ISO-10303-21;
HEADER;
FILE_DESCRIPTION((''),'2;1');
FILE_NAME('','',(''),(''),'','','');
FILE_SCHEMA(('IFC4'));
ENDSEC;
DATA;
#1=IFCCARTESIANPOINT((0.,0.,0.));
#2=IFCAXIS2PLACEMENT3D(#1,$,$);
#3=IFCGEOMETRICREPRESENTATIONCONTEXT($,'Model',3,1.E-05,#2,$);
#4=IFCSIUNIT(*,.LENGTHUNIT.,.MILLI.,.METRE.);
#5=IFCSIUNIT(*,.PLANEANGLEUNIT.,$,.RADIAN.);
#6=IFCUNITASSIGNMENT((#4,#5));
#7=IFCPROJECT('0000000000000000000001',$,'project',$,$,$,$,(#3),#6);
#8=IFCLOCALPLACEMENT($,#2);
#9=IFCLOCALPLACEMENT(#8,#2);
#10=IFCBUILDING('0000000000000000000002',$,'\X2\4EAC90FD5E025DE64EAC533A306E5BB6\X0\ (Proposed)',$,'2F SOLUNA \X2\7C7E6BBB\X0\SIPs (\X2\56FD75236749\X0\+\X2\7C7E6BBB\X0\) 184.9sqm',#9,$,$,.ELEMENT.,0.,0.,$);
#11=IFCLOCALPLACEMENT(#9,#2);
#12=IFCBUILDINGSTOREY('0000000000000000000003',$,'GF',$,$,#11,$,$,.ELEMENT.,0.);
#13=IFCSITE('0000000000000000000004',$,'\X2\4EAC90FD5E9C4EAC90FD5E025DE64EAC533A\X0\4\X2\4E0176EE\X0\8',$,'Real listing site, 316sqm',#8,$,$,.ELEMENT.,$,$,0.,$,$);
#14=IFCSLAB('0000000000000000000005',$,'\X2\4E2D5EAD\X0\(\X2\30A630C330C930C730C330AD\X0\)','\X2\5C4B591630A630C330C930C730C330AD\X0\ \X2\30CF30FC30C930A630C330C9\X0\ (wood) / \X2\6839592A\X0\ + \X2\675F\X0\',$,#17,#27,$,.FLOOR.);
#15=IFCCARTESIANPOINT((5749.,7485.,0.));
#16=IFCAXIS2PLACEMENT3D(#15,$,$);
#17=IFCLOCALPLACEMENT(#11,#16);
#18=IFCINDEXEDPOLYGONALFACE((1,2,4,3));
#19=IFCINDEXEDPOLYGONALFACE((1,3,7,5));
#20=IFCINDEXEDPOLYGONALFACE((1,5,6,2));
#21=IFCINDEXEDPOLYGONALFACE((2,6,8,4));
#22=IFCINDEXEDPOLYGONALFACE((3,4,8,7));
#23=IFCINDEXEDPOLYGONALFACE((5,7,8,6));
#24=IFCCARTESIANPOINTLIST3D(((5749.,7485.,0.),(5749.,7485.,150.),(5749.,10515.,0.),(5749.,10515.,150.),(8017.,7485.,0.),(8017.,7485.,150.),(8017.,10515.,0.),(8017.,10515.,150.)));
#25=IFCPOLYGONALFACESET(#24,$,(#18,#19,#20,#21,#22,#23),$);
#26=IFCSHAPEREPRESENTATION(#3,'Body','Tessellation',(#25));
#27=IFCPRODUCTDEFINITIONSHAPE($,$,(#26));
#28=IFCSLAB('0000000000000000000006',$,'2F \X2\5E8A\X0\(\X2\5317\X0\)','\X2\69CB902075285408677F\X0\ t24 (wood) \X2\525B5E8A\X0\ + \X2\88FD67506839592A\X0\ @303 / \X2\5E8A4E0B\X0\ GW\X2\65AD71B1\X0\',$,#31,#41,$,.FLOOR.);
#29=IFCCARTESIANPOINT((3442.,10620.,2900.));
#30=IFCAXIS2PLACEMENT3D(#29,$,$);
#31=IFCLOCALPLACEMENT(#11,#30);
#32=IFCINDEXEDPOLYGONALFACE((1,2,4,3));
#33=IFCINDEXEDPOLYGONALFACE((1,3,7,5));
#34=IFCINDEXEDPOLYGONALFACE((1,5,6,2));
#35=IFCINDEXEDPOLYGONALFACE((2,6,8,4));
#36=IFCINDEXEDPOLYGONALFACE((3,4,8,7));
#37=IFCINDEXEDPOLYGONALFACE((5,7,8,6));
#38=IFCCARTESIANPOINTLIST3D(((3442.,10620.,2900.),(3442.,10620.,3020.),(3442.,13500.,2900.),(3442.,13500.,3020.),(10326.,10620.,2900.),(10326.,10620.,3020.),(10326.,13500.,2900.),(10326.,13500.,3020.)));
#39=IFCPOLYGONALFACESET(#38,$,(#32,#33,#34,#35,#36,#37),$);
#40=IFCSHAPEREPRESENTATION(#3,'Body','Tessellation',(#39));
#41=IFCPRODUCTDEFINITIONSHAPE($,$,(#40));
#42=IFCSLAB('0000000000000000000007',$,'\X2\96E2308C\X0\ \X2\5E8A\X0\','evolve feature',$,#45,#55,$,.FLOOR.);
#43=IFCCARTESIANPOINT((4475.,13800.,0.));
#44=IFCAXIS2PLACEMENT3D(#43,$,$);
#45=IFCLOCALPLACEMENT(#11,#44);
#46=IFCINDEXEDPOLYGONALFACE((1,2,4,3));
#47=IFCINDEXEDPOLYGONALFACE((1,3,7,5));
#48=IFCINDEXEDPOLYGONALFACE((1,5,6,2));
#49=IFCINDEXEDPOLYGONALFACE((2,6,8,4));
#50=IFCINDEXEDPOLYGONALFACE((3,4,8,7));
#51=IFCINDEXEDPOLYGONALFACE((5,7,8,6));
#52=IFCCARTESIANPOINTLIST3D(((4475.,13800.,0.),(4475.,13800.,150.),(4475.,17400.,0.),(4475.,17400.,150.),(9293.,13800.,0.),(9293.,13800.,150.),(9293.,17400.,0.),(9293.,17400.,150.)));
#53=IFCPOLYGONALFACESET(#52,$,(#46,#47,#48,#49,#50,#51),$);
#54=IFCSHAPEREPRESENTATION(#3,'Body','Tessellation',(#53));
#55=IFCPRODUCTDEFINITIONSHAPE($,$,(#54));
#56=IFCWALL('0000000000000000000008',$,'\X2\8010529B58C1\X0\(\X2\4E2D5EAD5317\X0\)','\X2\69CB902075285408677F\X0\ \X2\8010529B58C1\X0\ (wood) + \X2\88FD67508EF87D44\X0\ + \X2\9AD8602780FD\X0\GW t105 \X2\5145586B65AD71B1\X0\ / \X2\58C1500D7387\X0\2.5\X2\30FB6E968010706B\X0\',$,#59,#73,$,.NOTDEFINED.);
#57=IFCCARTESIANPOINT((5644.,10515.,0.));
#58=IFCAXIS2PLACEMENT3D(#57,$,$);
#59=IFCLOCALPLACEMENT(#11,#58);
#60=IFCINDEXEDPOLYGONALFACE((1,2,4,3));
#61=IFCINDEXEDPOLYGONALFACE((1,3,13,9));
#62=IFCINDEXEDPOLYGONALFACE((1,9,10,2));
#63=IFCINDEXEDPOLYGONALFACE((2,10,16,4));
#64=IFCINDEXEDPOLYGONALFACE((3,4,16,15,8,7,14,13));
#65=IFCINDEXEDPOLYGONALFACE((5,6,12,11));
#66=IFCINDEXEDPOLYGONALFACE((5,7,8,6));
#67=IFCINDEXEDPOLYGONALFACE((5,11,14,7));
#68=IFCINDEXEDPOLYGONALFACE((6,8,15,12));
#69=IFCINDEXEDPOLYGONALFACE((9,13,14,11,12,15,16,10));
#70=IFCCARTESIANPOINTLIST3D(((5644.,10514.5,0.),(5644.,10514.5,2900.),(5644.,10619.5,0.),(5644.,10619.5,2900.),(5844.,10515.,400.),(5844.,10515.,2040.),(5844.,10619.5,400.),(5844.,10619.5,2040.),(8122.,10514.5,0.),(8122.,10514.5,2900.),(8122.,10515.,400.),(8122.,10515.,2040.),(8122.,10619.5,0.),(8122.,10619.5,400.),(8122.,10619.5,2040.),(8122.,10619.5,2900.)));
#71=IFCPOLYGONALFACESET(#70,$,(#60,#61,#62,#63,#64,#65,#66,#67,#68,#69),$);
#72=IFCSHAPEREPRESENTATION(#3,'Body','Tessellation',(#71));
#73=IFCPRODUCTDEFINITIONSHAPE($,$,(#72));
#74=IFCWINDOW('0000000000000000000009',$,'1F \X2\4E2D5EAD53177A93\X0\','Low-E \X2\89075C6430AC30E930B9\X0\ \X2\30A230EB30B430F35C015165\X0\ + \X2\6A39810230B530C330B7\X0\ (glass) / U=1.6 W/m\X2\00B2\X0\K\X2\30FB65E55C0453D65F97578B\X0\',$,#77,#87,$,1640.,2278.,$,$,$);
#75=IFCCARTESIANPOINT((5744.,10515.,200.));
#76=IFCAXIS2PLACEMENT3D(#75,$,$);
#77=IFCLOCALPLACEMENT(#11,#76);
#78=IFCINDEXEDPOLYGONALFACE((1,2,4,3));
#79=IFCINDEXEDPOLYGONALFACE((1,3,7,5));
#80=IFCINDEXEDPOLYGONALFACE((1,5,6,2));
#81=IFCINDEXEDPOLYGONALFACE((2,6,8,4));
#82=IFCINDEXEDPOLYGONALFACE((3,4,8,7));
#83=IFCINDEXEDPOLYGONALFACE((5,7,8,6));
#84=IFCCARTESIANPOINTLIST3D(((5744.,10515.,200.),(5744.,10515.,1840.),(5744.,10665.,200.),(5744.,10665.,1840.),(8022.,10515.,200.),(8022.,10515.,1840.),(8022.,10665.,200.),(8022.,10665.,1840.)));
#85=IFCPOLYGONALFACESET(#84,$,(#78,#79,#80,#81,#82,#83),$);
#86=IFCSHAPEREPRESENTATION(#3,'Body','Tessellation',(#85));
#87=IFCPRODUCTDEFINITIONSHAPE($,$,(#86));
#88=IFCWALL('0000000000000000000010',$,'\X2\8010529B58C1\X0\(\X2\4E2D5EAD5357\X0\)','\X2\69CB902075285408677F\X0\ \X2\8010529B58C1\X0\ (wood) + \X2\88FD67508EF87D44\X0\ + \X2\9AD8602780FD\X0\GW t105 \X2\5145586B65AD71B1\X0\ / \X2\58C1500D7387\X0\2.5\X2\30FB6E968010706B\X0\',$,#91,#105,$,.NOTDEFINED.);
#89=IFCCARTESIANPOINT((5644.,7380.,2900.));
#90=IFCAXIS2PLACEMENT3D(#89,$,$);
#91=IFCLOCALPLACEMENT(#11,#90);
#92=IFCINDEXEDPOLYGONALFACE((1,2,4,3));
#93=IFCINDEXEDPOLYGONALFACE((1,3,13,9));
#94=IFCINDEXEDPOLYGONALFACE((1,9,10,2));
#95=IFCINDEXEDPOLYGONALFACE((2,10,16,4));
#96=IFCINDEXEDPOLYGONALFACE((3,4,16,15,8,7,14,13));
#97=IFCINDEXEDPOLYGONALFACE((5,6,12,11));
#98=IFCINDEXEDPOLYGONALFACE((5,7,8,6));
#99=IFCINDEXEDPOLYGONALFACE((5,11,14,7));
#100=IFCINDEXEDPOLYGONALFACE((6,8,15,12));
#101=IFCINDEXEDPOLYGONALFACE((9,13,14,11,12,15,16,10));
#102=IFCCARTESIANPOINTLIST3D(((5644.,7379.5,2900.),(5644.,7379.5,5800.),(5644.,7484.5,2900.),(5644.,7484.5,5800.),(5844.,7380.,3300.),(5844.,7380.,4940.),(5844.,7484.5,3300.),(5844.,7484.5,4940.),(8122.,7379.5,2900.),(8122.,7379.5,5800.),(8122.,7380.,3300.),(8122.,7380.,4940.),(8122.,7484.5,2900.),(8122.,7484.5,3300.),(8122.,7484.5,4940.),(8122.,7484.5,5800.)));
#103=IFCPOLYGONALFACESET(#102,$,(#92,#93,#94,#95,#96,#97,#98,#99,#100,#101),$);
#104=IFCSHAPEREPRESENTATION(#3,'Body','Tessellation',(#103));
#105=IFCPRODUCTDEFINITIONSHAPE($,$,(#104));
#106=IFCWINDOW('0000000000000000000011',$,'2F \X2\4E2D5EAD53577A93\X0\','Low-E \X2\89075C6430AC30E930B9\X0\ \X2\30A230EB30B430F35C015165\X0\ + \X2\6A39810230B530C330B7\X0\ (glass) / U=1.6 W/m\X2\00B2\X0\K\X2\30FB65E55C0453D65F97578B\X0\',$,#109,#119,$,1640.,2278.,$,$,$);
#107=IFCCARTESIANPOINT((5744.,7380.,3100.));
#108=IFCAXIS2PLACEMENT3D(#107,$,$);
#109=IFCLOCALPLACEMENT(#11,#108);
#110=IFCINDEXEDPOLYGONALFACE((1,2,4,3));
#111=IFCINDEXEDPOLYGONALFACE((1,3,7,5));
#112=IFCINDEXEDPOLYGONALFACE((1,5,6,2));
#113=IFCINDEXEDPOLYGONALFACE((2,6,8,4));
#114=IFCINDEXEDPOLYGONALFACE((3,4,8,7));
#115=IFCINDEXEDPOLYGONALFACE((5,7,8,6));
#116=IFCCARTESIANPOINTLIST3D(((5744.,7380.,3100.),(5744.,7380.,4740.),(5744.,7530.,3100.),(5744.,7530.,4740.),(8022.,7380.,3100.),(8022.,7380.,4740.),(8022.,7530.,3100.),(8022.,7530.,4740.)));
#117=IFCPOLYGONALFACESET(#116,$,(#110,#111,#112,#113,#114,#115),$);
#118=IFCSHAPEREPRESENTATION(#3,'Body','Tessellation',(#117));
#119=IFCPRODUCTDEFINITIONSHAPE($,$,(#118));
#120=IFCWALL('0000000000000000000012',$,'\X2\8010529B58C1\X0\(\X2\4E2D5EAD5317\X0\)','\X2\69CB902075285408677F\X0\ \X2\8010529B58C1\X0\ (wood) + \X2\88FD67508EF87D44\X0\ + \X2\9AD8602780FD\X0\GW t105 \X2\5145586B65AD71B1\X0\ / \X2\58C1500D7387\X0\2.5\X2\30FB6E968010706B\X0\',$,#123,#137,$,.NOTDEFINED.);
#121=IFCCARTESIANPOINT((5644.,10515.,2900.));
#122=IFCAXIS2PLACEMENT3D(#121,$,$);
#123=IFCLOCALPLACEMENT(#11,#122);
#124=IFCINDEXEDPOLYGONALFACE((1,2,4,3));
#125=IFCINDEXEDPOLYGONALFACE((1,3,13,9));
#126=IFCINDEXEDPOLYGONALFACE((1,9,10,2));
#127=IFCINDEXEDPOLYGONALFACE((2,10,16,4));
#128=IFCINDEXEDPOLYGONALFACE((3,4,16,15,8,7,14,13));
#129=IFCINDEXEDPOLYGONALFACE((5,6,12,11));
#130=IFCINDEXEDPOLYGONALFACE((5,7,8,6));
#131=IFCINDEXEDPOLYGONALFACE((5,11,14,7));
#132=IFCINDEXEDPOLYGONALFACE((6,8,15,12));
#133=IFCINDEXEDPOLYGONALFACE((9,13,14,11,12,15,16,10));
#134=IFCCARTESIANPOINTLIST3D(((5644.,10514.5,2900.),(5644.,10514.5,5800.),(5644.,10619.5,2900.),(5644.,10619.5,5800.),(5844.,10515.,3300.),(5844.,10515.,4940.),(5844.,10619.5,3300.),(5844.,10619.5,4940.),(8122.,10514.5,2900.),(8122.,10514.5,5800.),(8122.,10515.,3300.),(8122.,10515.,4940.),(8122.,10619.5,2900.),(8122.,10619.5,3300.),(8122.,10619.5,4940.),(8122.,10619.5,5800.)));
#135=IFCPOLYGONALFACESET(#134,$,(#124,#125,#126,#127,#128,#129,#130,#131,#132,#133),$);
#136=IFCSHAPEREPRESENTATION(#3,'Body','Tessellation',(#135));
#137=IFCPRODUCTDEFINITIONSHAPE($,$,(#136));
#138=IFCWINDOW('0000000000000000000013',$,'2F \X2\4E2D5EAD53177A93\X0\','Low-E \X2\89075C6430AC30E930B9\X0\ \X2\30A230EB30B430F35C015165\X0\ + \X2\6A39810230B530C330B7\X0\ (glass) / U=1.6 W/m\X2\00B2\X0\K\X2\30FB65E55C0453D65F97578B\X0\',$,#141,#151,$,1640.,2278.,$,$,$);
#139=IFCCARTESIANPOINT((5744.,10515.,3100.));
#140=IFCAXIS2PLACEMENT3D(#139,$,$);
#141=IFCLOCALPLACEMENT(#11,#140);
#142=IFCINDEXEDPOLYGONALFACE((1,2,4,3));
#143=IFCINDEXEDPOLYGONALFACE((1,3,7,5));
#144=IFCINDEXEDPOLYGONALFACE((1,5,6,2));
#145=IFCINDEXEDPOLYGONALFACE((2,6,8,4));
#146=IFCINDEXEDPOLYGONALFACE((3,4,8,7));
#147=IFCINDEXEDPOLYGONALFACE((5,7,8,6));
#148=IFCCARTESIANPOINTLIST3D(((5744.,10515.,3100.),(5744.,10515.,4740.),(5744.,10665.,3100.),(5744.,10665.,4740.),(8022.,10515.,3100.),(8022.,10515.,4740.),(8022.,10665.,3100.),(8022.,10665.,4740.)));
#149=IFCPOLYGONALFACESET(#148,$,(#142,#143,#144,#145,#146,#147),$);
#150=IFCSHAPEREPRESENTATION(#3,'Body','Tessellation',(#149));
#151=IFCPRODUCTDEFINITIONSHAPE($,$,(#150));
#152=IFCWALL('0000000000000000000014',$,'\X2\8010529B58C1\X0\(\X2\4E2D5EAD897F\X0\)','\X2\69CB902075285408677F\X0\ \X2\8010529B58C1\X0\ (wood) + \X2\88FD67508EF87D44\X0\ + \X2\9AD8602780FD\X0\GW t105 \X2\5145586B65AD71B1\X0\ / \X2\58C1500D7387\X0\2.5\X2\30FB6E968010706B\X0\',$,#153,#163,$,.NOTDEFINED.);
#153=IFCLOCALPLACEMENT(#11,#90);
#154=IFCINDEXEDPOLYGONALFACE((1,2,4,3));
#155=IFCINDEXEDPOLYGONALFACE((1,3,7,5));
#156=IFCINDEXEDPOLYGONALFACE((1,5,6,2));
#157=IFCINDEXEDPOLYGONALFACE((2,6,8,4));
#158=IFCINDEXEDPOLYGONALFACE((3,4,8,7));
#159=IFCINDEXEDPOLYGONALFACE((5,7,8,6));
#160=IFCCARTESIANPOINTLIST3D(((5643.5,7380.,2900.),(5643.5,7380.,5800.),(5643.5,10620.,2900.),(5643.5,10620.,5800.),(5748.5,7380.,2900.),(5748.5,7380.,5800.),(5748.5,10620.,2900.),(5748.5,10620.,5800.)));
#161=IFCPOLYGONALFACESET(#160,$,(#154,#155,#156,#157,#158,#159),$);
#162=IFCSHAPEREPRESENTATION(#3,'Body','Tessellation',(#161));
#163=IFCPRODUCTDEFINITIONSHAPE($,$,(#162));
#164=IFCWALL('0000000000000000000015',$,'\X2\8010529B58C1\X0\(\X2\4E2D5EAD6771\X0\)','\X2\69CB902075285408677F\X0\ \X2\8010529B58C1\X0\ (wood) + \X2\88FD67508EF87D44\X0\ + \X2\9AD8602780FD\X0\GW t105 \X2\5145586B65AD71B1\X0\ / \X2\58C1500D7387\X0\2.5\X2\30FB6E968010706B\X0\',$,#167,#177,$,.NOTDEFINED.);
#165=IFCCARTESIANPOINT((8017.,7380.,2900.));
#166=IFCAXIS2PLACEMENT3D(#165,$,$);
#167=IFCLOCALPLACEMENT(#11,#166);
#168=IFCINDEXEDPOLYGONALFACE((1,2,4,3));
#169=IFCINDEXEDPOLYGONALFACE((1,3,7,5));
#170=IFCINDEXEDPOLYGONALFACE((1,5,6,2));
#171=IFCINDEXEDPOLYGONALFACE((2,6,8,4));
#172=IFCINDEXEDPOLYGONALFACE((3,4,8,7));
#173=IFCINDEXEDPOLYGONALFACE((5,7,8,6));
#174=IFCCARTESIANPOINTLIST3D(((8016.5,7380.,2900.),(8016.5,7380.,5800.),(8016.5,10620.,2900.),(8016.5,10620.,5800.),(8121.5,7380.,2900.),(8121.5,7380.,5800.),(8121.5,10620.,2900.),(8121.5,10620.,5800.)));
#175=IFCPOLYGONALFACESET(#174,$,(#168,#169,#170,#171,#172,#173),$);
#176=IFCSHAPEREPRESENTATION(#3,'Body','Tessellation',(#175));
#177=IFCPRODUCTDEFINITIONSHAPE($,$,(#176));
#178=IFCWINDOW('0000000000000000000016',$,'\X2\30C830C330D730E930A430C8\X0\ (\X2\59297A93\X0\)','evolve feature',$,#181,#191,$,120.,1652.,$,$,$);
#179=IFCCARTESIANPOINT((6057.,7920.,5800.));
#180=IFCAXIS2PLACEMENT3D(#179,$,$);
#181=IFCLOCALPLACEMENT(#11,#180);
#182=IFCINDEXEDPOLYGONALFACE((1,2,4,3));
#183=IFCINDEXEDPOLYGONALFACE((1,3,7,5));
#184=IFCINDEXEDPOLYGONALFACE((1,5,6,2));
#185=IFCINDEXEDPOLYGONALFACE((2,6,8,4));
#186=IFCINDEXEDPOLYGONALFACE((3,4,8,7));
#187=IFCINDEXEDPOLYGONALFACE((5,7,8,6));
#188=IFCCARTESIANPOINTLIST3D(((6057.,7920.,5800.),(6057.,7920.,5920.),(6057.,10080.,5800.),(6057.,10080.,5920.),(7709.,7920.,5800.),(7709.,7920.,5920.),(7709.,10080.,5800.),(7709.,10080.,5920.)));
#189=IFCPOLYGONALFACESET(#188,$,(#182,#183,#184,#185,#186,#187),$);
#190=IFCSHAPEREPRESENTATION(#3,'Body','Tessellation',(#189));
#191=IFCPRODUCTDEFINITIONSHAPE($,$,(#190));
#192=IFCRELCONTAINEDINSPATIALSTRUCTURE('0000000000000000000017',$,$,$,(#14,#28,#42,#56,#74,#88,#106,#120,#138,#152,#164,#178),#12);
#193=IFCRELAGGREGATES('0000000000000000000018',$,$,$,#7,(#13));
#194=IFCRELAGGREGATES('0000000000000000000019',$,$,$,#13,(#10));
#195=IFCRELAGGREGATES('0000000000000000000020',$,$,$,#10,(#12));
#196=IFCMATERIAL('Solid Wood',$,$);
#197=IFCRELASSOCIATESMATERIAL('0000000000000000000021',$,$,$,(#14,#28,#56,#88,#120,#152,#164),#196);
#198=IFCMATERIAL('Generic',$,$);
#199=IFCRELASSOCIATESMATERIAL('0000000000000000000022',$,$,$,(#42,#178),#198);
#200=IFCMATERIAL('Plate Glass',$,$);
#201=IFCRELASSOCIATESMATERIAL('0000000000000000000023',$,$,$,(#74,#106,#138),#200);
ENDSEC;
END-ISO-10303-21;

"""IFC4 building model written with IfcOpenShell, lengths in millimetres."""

from ifc_helpers import new_model, si_unit, frame, frame_2d, origin, place, context, project, spatial, rectangle, extrude, material, element, fill, save


model = new_model("IFC4")

# Units and contexts
model_context = context("Model", 3, precision=1e-05, world=origin())
ifc_project = project(units=[si_unit("LENGTHUNIT", "METRE", prefix="MILLI"), si_unit("PLANEANGLEUNIT", "RADIAN")], contexts=[model_context])

# Site, building, storey
site_placement = place(None, origin())
site = spatial("IfcSite", under=ifc_project, at=site_placement, Name="京都府京都市左京区4丁目8", ObjectType="Real listing site, 316sqm", CompositionType="ELEMENT", RefElevation=0.0)
building_placement = place(site_placement, origin())
building = spatial("IfcBuilding", under=site, at=building_placement, Name="京都市左京区の家 (Proposed)", ObjectType="2F SOLUNA 籾殻SIPs (国産杉+籾殻) 184.9sqm", CompositionType="ELEMENT", ElevationOfRefHeight=0.0, ElevationOfTerrain=0.0)
storey_placement = place(building_placement, origin())
storey = spatial("IfcBuildingStorey", under=building, at=storey_placement, Name="GF", CompositionType="ELEMENT", Elevation=0.0)

# Slabs
ifc_material_1 = material(Name="Solid Wood")
slab_1_placement = place(storey_placement, frame((5749.0, 7485.0, 0.0)))
element("IfcSlab", 1, at=slab_1_placement, inside=storey, material=ifc_material_1, Name="中庭(ウッドデッキ)", Description="屋外ウッドデッキ ハードウッド (wood) / 根太 + 束", PredefinedType="FLOOR", context=model_context, shape_type="SweptSolid", body=[
    extrude(rectangle(XDim=2268.0, YDim=3030.0, at=frame_2d((1134.0, 1515.0))), frame((5749.0, 7485.0, 0.0)), (0.0, 0.0, 1.0), 150.0),
])
slab_2_placement = place(storey_placement, frame((3442.0, 10620.0, 2900.0)))
element("IfcSlab", 2, at=slab_2_placement, inside=storey, material=ifc_material_1, Name="2F 床(北)", Description="構造用合板 t24 (wood) 剛床 + 製材根太 @303 / 床下 GW断熱", PredefinedType="FLOOR", context=model_context, shape_type="SweptSolid", body=[
    extrude(rectangle(XDim=6884.0, YDim=2880.0, at=frame_2d((3442.0, 1440.0))), frame((3442.0, 10620.0, 2900.0)), (0.0, 0.0, 1.0), 120.0),
])
ifc_material_2 = material(Name="Generic")
slab_3_placement = place(storey_placement, frame((4475.0, 13800.0, 0.0)))
element("IfcSlab", 3, at=slab_3_placement, inside=storey, material=ifc_material_2, Name="離れ 床", Description="evolve feature", PredefinedType="FLOOR", context=model_context, shape_type="SweptSolid", body=[
    extrude(rectangle(XDim=4818.0, YDim=3600.0, at=frame_2d((2409.0, 1800.0))), frame((4475.0, 13800.0, 0.0)), (0.0, 0.0, 1.0), 150.0),
])

# Wall, opening, window
wall_1_placement = place(storey_placement, frame((5644.0, 10515.0, 0.0)))
wall_1 = element("IfcWall", 4, at=wall_1_placement, inside=storey, material=ifc_material_1, Name="耐力壁(中庭北)", Description="構造用合板 耐力壁 (wood) + 製材軸組 + 高性能GW t105 充填断熱 / 壁倍率2.5・準耐火", PredefinedType="NOTDEFINED", context=model_context, shape_type="SweptSolid", body=[
    extrude(rectangle(XDim=2478.0, YDim=105.0, at=frame_2d((1239.0, 52.0))), frame((5644.0, 10515.0, 0.0)), (0.0, 0.0, 1.0), 2900.0),
])
opening_1_placement = place(storey_placement, frame((5744.0, 10515.0, 200.0)))
opening_1 = element("IfcOpeningElement", 5, at=opening_1_placement, cuts=wall_1, PredefinedType="NOTDEFINED", context=model_context, shape_type="SweptSolid", body=[
    extrude(rectangle(XDim=2278.0, YDim=150.0, at=frame_2d((1139.0, 75.0))), frame((5744.0, 10515.0, 200.0)), (0.0, 0.0, 1.0), 1640.0),
])
ifc_material_3 = material(Name="Plate Glass")
window_1_placement = place(storey_placement, frame((5744.0, 10515.0, 200.0)))
window_1 = element("IfcWindow", 6, at=window_1_placement, inside=storey, material=ifc_material_3, Name="1F 中庭北窓", Description="Low-E 複層ガラス アルゴン封入 + 樹脂サッシ (glass) / U=1.6 W/m²K・日射取得型", OverallHeight=1640.0, OverallWidth=2278.0, context=model_context, shape_type="SweptSolid", body=[
    extrude(rectangle(XDim=2278.0, YDim=150.0, at=frame_2d((1139.0, 75.0))), frame((5744.0, 10515.0, 200.0)), (0.0, 0.0, 1.0), 1640.0),
])
fill(opening_1, window_1)

# Walls, openings, windows
wall_2_placement = place(storey_placement, frame((5644.0, 7380.0, 2900.0)))
wall_2 = element("IfcWall", 7, at=wall_2_placement, inside=storey, material=ifc_material_1, Name="耐力壁(中庭南)", Description="構造用合板 耐力壁 (wood) + 製材軸組 + 高性能GW t105 充填断熱 / 壁倍率2.5・準耐火", PredefinedType="NOTDEFINED", context=model_context, shape_type="SweptSolid", body=[
    extrude(rectangle(XDim=2478.0, YDim=105.0, at=frame_2d((1239.0, 52.0))), frame((5644.0, 7380.0, 2900.0)), (0.0, 0.0, 1.0), 2900.0),
])
opening_2_placement = place(storey_placement, frame((5744.0, 7380.0, 3100.0)))
opening_2 = element("IfcOpeningElement", 8, at=opening_2_placement, cuts=wall_2, PredefinedType="NOTDEFINED", context=model_context, shape_type="SweptSolid", body=[
    extrude(rectangle(XDim=2278.0, YDim=150.0, at=frame_2d((1139.0, 75.0))), frame((5744.0, 7380.0, 3100.0)), (0.0, 0.0, 1.0), 1640.0),
])
window_2_placement = place(storey_placement, frame((5744.0, 7380.0, 3100.0)))
window_2 = element("IfcWindow", 9, at=window_2_placement, inside=storey, material=ifc_material_3, Name="2F 中庭南窓", Description="Low-E 複層ガラス アルゴン封入 + 樹脂サッシ (glass) / U=1.6 W/m²K・日射取得型", OverallHeight=1640.0, OverallWidth=2278.0, context=model_context, shape_type="SweptSolid", body=[
    extrude(rectangle(XDim=2278.0, YDim=150.0, at=frame_2d((1139.0, 75.0))), frame((5744.0, 7380.0, 3100.0)), (0.0, 0.0, 1.0), 1640.0),
])
fill(opening_2, window_2)
wall_3_placement = place(storey_placement, frame((5644.0, 10515.0, 2900.0)))
wall_3 = element("IfcWall", 10, at=wall_3_placement, inside=storey, material=ifc_material_1, Name="耐力壁(中庭北)", Description="構造用合板 耐力壁 (wood) + 製材軸組 + 高性能GW t105 充填断熱 / 壁倍率2.5・準耐火", PredefinedType="NOTDEFINED", context=model_context, shape_type="SweptSolid", body=[
    extrude(rectangle(XDim=2478.0, YDim=105.0, at=frame_2d((1239.0, 52.0))), frame((5644.0, 10515.0, 2900.0)), (0.0, 0.0, 1.0), 2900.0),
])
opening_3_placement = place(storey_placement, frame((5744.0, 10515.0, 3100.0)))
opening_3 = element("IfcOpeningElement", 11, at=opening_3_placement, cuts=wall_3, PredefinedType="NOTDEFINED", context=model_context, shape_type="SweptSolid", body=[
    extrude(rectangle(XDim=2278.0, YDim=150.0, at=frame_2d((1139.0, 75.0))), frame((5744.0, 10515.0, 3100.0)), (0.0, 0.0, 1.0), 1640.0),
])
window_3_placement = place(storey_placement, frame((5744.0, 10515.0, 3100.0)))
window_3 = element("IfcWindow", 12, at=window_3_placement, inside=storey, material=ifc_material_3, Name="2F 中庭北窓", Description="Low-E 複層ガラス アルゴン封入 + 樹脂サッシ (glass) / U=1.6 W/m²K・日射取得型", OverallHeight=1640.0, OverallWidth=2278.0, context=model_context, shape_type="SweptSolid", body=[
    extrude(rectangle(XDim=2278.0, YDim=150.0, at=frame_2d((1139.0, 75.0))), frame((5744.0, 10515.0, 3100.0)), (0.0, 0.0, 1.0), 1640.0),
])
fill(opening_3, window_3)

# Walls
wall_4_placement = place(storey_placement, frame((5644.0, 7380.0, 2900.0)))
element("IfcWall", 13, at=wall_4_placement, inside=storey, material=ifc_material_1, Name="耐力壁(中庭西)", Description="構造用合板 耐力壁 (wood) + 製材軸組 + 高性能GW t105 充填断熱 / 壁倍率2.5・準耐火", PredefinedType="NOTDEFINED", context=model_context, shape_type="SweptSolid", body=[
    extrude(rectangle(XDim=105.0, YDim=3240.0, at=frame_2d((52.0, 1620.0))), frame((5644.0, 7380.0, 2900.0)), (0.0, 0.0, 1.0), 2900.0),
])
wall_5_placement = place(storey_placement, frame((8017.0, 7380.0, 2900.0)))
element("IfcWall", 14, at=wall_5_placement, inside=storey, material=ifc_material_1, Name="耐力壁(中庭東)", Description="構造用合板 耐力壁 (wood) + 製材軸組 + 高性能GW t105 充填断熱 / 壁倍率2.5・準耐火", PredefinedType="NOTDEFINED", context=model_context, shape_type="SweptSolid", body=[
    extrude(rectangle(XDim=105.0, YDim=3240.0, at=frame_2d((52.0, 1620.0))), frame((8017.0, 7380.0, 2900.0)), (0.0, 0.0, 1.0), 2900.0),
])

# Window
window_4_placement = place(storey_placement, frame((6057.0, 7920.0, 5800.0)))
element("IfcWindow", 15, at=window_4_placement, inside=storey, material=ifc_material_2, Name="トップライト (天窓)", Description="evolve feature", OverallHeight=120.0, OverallWidth=1652.0, context=model_context, shape_type="SweptSolid", body=[
    extrude(rectangle(XDim=1652.0, YDim=2160.0, at=frame_2d((826.0, 1080.0))), frame((6057.0, 7920.0, 5800.0)), (0.0, 0.0, 1.0), 120.0),
])

save(model, "model.ifc")
